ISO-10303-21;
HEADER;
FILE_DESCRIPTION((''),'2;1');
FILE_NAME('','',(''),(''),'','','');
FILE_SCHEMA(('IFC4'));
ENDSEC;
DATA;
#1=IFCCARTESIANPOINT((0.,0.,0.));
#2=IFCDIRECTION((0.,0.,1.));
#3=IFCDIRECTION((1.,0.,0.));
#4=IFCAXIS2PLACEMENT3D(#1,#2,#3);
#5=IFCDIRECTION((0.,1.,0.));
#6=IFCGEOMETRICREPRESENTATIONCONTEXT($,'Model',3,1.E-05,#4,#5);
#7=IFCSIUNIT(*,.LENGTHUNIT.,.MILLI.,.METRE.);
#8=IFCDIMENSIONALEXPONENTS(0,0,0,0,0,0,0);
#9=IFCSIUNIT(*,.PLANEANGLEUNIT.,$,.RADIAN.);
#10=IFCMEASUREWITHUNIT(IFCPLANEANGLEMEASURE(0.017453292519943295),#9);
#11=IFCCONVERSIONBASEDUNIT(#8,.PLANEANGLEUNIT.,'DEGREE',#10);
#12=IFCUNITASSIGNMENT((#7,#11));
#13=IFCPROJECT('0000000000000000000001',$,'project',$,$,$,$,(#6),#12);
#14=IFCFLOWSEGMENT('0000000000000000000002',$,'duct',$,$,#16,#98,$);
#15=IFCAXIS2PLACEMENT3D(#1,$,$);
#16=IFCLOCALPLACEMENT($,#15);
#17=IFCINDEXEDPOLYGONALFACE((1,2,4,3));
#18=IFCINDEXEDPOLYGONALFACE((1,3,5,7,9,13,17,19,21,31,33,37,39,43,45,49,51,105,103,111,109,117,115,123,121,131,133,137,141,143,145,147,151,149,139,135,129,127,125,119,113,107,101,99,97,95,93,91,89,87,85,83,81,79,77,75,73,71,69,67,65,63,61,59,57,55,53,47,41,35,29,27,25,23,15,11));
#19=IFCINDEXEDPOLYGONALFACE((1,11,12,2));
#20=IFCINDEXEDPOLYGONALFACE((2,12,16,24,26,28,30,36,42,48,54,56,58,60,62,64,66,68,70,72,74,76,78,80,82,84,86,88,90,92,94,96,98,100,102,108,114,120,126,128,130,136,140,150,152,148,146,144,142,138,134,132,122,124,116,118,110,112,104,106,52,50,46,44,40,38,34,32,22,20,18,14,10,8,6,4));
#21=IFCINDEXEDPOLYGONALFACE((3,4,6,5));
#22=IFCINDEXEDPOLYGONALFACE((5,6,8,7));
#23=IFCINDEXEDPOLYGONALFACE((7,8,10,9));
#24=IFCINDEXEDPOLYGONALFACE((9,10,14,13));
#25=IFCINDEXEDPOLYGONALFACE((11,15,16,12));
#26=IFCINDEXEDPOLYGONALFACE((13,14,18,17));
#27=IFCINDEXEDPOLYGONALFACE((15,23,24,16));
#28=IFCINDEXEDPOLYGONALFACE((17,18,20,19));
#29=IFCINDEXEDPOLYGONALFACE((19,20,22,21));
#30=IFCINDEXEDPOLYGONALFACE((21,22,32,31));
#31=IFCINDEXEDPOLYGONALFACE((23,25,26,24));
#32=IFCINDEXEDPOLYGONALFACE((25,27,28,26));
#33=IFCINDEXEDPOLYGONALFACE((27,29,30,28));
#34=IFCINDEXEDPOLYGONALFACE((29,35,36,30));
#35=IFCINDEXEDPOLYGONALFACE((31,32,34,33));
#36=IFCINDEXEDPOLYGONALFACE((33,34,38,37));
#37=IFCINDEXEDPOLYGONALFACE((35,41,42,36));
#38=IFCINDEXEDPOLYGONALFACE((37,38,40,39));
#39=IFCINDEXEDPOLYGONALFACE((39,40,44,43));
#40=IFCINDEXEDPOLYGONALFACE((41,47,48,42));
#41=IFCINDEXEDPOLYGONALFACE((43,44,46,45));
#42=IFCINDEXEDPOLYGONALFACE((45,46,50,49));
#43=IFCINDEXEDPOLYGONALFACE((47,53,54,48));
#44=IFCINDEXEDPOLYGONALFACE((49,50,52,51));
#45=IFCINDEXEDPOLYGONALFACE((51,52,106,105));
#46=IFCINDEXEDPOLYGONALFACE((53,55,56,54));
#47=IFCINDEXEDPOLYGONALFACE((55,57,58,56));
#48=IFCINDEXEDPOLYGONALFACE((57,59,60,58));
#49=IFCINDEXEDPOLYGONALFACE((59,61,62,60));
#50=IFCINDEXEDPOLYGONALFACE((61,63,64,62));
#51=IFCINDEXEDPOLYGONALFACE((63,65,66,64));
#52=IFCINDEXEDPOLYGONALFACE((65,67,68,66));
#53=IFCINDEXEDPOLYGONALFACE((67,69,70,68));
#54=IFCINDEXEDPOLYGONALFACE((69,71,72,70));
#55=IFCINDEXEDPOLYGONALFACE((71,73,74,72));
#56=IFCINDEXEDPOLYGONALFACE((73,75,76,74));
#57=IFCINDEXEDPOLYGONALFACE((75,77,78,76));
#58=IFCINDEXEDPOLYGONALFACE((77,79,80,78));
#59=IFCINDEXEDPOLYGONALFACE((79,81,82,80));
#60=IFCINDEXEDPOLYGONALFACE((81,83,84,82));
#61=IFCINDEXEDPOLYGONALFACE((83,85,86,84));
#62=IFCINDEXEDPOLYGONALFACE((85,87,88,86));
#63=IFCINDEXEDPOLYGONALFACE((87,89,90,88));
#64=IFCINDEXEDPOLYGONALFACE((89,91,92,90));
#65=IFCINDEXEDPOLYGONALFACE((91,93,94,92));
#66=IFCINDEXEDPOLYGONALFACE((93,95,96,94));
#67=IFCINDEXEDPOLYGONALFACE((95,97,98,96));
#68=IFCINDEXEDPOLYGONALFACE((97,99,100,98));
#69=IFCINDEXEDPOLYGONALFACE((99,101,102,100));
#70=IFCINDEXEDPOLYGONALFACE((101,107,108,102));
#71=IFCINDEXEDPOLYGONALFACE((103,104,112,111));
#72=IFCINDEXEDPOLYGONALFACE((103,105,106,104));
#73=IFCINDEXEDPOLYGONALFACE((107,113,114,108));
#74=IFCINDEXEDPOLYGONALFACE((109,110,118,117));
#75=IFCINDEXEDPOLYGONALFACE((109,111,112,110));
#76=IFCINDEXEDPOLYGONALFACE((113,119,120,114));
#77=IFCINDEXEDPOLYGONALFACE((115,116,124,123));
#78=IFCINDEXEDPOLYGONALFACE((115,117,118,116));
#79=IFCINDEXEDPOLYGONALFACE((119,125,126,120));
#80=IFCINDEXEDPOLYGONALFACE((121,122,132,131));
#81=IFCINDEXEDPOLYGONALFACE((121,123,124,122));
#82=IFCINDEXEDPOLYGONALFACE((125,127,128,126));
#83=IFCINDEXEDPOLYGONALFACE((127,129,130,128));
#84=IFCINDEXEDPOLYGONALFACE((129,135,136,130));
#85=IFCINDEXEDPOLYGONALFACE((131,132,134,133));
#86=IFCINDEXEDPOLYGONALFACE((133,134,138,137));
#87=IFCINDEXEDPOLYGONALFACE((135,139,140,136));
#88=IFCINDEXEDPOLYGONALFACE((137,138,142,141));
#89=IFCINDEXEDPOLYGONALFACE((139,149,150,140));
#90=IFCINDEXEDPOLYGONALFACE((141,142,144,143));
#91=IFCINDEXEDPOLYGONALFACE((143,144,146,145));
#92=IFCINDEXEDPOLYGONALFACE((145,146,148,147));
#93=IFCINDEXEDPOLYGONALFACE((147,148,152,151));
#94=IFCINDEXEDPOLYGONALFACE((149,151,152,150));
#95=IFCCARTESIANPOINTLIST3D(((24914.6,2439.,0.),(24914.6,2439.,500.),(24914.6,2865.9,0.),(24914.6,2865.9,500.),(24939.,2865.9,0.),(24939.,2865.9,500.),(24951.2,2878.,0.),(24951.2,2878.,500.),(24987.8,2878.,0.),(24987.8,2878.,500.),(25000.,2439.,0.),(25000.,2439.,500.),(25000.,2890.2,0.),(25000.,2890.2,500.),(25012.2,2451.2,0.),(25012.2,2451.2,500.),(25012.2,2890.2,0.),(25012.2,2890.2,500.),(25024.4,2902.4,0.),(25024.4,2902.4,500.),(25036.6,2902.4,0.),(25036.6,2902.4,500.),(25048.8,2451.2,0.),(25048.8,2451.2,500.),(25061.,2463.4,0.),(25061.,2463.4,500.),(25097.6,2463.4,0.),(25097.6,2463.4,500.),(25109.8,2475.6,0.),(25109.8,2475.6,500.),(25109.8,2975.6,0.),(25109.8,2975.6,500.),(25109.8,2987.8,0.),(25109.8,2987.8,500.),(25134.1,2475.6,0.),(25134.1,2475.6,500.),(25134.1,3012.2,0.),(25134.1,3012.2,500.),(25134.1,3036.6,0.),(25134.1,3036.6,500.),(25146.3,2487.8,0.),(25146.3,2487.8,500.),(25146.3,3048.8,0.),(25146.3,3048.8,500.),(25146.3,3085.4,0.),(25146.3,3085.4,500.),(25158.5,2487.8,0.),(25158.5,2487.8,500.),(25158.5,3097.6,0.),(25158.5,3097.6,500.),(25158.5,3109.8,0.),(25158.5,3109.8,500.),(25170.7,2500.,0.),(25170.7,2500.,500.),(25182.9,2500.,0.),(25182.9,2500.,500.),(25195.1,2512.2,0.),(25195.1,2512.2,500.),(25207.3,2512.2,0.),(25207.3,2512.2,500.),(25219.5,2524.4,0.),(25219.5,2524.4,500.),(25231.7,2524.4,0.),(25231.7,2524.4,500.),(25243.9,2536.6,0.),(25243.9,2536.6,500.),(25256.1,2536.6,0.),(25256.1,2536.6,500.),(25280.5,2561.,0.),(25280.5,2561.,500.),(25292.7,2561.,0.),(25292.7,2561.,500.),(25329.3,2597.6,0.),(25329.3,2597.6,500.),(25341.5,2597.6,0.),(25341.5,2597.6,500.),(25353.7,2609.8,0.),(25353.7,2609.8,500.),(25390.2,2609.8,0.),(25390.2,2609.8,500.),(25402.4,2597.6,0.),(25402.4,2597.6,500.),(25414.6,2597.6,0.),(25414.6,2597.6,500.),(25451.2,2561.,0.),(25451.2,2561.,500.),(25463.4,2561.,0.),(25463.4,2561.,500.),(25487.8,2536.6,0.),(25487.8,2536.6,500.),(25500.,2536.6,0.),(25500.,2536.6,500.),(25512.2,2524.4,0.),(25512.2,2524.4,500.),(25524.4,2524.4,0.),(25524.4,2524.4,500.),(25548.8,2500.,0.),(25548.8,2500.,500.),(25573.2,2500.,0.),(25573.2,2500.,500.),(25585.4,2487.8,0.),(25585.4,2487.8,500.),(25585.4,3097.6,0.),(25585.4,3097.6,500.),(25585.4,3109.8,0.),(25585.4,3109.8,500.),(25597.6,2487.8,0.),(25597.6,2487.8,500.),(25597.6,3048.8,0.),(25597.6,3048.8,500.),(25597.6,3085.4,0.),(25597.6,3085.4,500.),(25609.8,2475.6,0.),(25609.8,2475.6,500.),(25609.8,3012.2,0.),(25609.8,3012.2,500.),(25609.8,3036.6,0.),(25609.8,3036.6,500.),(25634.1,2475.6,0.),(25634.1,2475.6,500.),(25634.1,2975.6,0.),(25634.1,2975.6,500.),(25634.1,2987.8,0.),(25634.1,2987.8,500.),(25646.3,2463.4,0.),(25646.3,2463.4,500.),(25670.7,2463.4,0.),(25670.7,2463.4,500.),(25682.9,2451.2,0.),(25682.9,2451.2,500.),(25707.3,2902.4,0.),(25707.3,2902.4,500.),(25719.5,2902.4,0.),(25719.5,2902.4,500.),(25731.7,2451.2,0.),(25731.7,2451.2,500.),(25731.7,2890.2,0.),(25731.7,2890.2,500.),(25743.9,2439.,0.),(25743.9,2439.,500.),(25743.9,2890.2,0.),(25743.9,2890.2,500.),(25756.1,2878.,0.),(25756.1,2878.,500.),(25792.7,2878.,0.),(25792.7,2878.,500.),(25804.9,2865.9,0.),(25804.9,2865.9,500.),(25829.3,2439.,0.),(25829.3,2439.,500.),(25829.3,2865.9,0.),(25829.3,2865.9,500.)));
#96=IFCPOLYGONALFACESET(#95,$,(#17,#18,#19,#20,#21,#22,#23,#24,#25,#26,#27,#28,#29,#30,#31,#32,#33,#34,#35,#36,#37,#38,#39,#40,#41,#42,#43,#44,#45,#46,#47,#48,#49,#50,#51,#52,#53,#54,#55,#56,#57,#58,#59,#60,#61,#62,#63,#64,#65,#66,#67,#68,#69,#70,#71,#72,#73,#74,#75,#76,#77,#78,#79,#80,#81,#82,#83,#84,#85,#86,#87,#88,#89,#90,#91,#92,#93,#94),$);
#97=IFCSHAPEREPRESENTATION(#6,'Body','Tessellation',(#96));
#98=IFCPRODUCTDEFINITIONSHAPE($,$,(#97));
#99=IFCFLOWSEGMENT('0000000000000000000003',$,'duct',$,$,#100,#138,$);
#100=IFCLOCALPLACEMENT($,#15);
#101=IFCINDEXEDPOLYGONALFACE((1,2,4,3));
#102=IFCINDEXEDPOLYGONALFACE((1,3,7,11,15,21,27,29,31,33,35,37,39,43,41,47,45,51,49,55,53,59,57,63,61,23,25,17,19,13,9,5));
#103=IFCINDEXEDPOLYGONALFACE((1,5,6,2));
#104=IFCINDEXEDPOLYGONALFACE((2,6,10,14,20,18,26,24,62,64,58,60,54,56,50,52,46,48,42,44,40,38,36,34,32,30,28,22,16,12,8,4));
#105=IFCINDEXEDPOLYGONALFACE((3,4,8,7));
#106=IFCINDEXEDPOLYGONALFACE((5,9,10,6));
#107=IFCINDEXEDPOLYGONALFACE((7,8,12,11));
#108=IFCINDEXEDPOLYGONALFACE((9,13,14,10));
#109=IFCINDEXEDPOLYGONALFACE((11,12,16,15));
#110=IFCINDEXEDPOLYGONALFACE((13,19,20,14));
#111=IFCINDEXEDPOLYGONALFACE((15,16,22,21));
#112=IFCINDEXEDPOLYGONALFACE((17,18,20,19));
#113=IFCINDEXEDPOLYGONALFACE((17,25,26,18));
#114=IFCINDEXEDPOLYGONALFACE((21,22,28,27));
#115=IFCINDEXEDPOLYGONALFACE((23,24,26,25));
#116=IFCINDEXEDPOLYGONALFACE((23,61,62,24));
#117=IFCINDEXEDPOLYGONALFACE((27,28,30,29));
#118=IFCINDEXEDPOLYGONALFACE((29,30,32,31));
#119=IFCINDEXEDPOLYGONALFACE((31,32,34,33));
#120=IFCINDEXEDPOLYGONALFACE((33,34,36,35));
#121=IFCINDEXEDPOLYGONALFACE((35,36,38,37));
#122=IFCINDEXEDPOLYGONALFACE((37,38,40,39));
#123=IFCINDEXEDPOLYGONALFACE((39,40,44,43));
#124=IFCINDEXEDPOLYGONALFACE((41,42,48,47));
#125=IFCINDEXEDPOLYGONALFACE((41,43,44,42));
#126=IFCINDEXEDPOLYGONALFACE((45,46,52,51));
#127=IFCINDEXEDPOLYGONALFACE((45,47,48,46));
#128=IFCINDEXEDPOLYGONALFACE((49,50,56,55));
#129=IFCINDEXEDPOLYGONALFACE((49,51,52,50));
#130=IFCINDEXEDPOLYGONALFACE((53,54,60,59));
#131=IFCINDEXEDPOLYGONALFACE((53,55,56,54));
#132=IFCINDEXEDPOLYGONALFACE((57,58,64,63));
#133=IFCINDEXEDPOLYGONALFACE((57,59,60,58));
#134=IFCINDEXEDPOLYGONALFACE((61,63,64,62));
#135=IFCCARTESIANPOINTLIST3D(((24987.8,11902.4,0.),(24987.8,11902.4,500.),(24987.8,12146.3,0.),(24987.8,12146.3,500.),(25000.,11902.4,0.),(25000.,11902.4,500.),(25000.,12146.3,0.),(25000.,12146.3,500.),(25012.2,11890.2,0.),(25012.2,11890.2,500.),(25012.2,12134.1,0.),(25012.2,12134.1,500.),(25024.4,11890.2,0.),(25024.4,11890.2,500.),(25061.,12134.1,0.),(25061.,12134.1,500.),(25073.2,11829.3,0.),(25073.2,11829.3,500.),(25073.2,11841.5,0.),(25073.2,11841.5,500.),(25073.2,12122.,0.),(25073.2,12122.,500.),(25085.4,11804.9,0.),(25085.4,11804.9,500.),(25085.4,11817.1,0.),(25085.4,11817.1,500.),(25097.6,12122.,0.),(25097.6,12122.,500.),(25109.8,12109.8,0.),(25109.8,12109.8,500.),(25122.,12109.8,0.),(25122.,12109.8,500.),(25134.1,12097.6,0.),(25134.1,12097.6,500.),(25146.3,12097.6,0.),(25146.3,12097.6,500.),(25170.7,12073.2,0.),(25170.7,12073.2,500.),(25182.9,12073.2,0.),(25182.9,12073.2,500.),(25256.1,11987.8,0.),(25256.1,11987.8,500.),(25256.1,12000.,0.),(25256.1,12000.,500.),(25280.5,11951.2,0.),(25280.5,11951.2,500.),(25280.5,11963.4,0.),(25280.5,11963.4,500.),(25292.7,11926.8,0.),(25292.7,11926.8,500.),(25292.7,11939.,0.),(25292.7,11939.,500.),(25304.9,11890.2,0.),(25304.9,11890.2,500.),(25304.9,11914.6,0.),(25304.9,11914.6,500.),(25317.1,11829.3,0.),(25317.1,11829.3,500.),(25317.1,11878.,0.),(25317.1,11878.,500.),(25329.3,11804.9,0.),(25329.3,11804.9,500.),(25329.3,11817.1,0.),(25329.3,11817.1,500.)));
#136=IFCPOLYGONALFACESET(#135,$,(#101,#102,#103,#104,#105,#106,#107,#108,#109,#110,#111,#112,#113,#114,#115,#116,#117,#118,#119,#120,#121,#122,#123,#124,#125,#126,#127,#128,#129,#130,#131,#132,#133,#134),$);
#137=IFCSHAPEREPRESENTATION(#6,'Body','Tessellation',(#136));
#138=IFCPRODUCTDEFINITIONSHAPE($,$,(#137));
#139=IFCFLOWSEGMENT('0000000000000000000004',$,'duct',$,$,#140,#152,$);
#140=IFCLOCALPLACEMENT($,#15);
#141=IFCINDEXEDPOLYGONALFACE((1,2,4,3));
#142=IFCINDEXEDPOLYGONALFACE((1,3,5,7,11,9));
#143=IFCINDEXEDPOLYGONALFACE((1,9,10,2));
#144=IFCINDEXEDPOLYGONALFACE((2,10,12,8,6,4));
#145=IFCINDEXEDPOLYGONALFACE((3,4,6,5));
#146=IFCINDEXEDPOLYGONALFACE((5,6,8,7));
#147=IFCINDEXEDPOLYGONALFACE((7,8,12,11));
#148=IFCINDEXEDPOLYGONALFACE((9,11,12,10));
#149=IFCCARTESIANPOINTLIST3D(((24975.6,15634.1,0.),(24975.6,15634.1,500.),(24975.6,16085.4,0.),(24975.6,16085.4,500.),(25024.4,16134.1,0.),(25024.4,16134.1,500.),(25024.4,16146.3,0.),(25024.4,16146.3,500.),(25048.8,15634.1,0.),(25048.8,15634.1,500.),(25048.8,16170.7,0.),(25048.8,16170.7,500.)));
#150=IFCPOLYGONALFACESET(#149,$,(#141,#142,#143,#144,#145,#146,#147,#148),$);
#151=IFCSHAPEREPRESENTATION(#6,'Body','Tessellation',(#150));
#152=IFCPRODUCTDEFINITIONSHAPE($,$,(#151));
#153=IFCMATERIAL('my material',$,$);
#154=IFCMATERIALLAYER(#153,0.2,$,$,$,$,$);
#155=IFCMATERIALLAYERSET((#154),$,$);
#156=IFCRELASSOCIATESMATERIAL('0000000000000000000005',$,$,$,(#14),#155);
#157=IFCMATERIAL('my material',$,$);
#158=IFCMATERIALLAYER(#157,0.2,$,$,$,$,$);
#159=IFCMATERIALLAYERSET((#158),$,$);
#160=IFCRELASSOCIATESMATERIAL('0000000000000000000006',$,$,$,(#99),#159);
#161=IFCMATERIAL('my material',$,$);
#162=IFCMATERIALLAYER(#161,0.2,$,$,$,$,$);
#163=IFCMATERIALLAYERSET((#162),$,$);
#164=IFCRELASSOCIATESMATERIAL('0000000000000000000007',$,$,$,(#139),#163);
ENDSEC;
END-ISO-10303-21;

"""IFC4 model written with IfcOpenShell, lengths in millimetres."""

from ifc_helpers import new_model, entity, si_unit, converted_unit, direction, origin_with_axes, place, context, project, polyline, outline, extrude, material, layer, layer_set, layer_usage, element, save


model = new_model("IFC4")

# Units and contexts
model_context = context("Model", 3, precision=1e-05, world=origin_with_axes(), true_north=direction((0.0, 1.0, 0.0)))
ifc_project = project(units=[si_unit("LENGTHUNIT", "METRE", prefix="MILLI"), converted_unit("PLANEANGLEUNIT", "DEGREE", entity("IfcPlaneAngleMeasure", 0.017453292519943295), si_unit("PLANEANGLEUNIT", "RADIAN"), dimensions=[0, 0, 0, 0, 0, 0, 0])], contexts=[model_context])

# Flow segments
ifc_material_1 = material(Name="my material")
ifc_layer_1 = layer(ifc_material_1, 0.2)
ifc_layer_set_1 = layer_set([ifc_layer_1])
ifc_layer_usage_1 = layer_usage(ifc_layer_set_1, "AXIS2", "POSITIVE", -0.1)
flow_segment_1_placement = place(None, origin_with_axes())
element("IfcFlowSegment", 1, at=flow_segment_1_placement, material=ifc_layer_usage_1, Name="duct", context=model_context, shape_type="SweptSolid", body=[
    extrude(outline(polyline([(24914.6, 2439.0), (25000.0, 2439.0), (25012.2, 2451.2), (25048.8, 2451.2), (25061.0, 2463.4), (25097.6, 2463.4), (25109.8, 2475.6), (25134.1, 2475.6), (25146.3, 2487.8), (25158.5, 2487.8), (25170.7, 2500.0), (25182.9, 2500.0), (25195.1, 2512.2), (25207.3, 2512.2), (25219.5, 2524.4), (25231.7, 2524.4), (25243.9, 2536.6), (25256.1, 2536.6), (25280.5, 2561.0), (25292.7, 2561.0), (25329.3, 2597.6), (25341.5, 2597.6), (25353.7, 2609.8), (25390.2, 2609.8), (25402.4, 2597.6), (25414.6, 2597.6), (25451.2, 2561.0), (25463.4, 2561.0), (25487.8, 2536.6), (25500.0, 2536.6), (25512.2, 2524.4), (25524.4, 2524.4), (25548.8, 2500.0), (25573.2, 2500.0), (25585.4, 2487.8), (25597.6, 2487.8), (25609.8, 2475.6), (25634.1, 2475.6), (25646.3, 2463.4), (25670.7, 2463.4), (25682.9, 2451.2), (25731.7, 2451.2), (25743.9, 2439.0), (25829.3, 2439.0), (25829.3, 2865.9), (25804.9, 2865.9), (25792.7, 2878.0), (25756.1, 2878.0), (25743.9, 2890.2), (25731.7, 2890.2), (25719.5, 2902.4), (25707.3, 2902.4), (25634.1, 2975.6), (25634.1, 2987.8), (25609.8, 3012.2), (25609.8, 3036.6), (25597.6, 3048.8), (25597.6, 3085.4), (25585.4, 3097.6), (25585.4, 3109.8), (25158.5, 3109.8), (25158.5, 3097.6), (25146.3, 3085.4), (25146.3, 3048.8), (25134.1, 3036.6), (25134.1, 3012.2), (25109.8, 2987.8), (25109.8, 2975.6), (25036.6, 2902.4), (25024.4, 2902.4), (25012.2, 2890.2), (25000.0, 2890.2), (24987.8, 2878.0), (24951.2, 2878.0), (24939.0, 2865.9), (24914.6, 2865.9), (24914.6, 2439.0)])), origin_with_axes(), (0.0, 0.0, 1.0), 500.0),
])
ifc_material_2 = material(Name="my material")
ifc_layer_2 = layer(ifc_material_2, 0.2)
ifc_layer_set_2 = layer_set([ifc_layer_2])
ifc_layer_usage_2 = layer_usage(ifc_layer_set_2, "AXIS2", "POSITIVE", -0.1)
flow_segment_2_placement = place(None, origin_with_axes())
element("IfcFlowSegment", 2, at=flow_segment_2_placement, material=ifc_layer_usage_2, Name="duct", context=model_context, shape_type="SweptSolid", body=[
    extrude(outline(polyline([(24987.8, 11902.4), (25000.0, 11902.4), (25012.2, 11890.2), (25024.4, 11890.2), (25073.2, 11841.5), (25073.2, 11829.3), (25085.4, 11817.1), (25085.4, 11804.9), (25329.3, 11804.9), (25329.3, 11817.1), (25317.1, 11829.3), (25317.1, 11878.0), (25304.9, 11890.2), (25304.9, 11914.6), (25292.7, 11926.8), (25292.7, 11939.0), (25280.5, 11951.2), (25280.5, 11963.4), (25256.1, 11987.8), (25256.1, 12000.0), (25182.9, 12073.2), (25170.7, 12073.2), (25146.3, 12097.6), (25134.1, 12097.6), (25122.0, 12109.8), (25109.8, 12109.8), (25097.6, 12122.0), (25073.2, 12122.0), (25061.0, 12134.1), (25012.2, 12134.1), (25000.0, 12146.3), (24987.8, 12146.3), (24987.8, 11902.4)])), origin_with_axes(), (0.0, 0.0, 1.0), 500.0),
])
ifc_material_3 = material(Name="my material")
ifc_layer_3 = layer(ifc_material_3, 0.2)
ifc_layer_set_3 = layer_set([ifc_layer_3])
ifc_layer_usage_3 = layer_usage(ifc_layer_set_3, "AXIS2", "POSITIVE", -0.1)
flow_segment_3_placement = place(None, origin_with_axes())
element("IfcFlowSegment", 3, at=flow_segment_3_placement, material=ifc_layer_usage_3, Name="duct", context=model_context, shape_type="SweptSolid", body=[
    extrude(outline(polyline([(24975.6, 15634.1), (25048.8, 15634.1), (25048.8, 16170.7), (25024.4, 16146.3), (25024.4, 16134.1), (24975.6, 16085.4), (24975.6, 15634.1)])), origin_with_axes(), (0.0, 0.0, 1.0), 500.0),
])

save(model, "model.ifc")
